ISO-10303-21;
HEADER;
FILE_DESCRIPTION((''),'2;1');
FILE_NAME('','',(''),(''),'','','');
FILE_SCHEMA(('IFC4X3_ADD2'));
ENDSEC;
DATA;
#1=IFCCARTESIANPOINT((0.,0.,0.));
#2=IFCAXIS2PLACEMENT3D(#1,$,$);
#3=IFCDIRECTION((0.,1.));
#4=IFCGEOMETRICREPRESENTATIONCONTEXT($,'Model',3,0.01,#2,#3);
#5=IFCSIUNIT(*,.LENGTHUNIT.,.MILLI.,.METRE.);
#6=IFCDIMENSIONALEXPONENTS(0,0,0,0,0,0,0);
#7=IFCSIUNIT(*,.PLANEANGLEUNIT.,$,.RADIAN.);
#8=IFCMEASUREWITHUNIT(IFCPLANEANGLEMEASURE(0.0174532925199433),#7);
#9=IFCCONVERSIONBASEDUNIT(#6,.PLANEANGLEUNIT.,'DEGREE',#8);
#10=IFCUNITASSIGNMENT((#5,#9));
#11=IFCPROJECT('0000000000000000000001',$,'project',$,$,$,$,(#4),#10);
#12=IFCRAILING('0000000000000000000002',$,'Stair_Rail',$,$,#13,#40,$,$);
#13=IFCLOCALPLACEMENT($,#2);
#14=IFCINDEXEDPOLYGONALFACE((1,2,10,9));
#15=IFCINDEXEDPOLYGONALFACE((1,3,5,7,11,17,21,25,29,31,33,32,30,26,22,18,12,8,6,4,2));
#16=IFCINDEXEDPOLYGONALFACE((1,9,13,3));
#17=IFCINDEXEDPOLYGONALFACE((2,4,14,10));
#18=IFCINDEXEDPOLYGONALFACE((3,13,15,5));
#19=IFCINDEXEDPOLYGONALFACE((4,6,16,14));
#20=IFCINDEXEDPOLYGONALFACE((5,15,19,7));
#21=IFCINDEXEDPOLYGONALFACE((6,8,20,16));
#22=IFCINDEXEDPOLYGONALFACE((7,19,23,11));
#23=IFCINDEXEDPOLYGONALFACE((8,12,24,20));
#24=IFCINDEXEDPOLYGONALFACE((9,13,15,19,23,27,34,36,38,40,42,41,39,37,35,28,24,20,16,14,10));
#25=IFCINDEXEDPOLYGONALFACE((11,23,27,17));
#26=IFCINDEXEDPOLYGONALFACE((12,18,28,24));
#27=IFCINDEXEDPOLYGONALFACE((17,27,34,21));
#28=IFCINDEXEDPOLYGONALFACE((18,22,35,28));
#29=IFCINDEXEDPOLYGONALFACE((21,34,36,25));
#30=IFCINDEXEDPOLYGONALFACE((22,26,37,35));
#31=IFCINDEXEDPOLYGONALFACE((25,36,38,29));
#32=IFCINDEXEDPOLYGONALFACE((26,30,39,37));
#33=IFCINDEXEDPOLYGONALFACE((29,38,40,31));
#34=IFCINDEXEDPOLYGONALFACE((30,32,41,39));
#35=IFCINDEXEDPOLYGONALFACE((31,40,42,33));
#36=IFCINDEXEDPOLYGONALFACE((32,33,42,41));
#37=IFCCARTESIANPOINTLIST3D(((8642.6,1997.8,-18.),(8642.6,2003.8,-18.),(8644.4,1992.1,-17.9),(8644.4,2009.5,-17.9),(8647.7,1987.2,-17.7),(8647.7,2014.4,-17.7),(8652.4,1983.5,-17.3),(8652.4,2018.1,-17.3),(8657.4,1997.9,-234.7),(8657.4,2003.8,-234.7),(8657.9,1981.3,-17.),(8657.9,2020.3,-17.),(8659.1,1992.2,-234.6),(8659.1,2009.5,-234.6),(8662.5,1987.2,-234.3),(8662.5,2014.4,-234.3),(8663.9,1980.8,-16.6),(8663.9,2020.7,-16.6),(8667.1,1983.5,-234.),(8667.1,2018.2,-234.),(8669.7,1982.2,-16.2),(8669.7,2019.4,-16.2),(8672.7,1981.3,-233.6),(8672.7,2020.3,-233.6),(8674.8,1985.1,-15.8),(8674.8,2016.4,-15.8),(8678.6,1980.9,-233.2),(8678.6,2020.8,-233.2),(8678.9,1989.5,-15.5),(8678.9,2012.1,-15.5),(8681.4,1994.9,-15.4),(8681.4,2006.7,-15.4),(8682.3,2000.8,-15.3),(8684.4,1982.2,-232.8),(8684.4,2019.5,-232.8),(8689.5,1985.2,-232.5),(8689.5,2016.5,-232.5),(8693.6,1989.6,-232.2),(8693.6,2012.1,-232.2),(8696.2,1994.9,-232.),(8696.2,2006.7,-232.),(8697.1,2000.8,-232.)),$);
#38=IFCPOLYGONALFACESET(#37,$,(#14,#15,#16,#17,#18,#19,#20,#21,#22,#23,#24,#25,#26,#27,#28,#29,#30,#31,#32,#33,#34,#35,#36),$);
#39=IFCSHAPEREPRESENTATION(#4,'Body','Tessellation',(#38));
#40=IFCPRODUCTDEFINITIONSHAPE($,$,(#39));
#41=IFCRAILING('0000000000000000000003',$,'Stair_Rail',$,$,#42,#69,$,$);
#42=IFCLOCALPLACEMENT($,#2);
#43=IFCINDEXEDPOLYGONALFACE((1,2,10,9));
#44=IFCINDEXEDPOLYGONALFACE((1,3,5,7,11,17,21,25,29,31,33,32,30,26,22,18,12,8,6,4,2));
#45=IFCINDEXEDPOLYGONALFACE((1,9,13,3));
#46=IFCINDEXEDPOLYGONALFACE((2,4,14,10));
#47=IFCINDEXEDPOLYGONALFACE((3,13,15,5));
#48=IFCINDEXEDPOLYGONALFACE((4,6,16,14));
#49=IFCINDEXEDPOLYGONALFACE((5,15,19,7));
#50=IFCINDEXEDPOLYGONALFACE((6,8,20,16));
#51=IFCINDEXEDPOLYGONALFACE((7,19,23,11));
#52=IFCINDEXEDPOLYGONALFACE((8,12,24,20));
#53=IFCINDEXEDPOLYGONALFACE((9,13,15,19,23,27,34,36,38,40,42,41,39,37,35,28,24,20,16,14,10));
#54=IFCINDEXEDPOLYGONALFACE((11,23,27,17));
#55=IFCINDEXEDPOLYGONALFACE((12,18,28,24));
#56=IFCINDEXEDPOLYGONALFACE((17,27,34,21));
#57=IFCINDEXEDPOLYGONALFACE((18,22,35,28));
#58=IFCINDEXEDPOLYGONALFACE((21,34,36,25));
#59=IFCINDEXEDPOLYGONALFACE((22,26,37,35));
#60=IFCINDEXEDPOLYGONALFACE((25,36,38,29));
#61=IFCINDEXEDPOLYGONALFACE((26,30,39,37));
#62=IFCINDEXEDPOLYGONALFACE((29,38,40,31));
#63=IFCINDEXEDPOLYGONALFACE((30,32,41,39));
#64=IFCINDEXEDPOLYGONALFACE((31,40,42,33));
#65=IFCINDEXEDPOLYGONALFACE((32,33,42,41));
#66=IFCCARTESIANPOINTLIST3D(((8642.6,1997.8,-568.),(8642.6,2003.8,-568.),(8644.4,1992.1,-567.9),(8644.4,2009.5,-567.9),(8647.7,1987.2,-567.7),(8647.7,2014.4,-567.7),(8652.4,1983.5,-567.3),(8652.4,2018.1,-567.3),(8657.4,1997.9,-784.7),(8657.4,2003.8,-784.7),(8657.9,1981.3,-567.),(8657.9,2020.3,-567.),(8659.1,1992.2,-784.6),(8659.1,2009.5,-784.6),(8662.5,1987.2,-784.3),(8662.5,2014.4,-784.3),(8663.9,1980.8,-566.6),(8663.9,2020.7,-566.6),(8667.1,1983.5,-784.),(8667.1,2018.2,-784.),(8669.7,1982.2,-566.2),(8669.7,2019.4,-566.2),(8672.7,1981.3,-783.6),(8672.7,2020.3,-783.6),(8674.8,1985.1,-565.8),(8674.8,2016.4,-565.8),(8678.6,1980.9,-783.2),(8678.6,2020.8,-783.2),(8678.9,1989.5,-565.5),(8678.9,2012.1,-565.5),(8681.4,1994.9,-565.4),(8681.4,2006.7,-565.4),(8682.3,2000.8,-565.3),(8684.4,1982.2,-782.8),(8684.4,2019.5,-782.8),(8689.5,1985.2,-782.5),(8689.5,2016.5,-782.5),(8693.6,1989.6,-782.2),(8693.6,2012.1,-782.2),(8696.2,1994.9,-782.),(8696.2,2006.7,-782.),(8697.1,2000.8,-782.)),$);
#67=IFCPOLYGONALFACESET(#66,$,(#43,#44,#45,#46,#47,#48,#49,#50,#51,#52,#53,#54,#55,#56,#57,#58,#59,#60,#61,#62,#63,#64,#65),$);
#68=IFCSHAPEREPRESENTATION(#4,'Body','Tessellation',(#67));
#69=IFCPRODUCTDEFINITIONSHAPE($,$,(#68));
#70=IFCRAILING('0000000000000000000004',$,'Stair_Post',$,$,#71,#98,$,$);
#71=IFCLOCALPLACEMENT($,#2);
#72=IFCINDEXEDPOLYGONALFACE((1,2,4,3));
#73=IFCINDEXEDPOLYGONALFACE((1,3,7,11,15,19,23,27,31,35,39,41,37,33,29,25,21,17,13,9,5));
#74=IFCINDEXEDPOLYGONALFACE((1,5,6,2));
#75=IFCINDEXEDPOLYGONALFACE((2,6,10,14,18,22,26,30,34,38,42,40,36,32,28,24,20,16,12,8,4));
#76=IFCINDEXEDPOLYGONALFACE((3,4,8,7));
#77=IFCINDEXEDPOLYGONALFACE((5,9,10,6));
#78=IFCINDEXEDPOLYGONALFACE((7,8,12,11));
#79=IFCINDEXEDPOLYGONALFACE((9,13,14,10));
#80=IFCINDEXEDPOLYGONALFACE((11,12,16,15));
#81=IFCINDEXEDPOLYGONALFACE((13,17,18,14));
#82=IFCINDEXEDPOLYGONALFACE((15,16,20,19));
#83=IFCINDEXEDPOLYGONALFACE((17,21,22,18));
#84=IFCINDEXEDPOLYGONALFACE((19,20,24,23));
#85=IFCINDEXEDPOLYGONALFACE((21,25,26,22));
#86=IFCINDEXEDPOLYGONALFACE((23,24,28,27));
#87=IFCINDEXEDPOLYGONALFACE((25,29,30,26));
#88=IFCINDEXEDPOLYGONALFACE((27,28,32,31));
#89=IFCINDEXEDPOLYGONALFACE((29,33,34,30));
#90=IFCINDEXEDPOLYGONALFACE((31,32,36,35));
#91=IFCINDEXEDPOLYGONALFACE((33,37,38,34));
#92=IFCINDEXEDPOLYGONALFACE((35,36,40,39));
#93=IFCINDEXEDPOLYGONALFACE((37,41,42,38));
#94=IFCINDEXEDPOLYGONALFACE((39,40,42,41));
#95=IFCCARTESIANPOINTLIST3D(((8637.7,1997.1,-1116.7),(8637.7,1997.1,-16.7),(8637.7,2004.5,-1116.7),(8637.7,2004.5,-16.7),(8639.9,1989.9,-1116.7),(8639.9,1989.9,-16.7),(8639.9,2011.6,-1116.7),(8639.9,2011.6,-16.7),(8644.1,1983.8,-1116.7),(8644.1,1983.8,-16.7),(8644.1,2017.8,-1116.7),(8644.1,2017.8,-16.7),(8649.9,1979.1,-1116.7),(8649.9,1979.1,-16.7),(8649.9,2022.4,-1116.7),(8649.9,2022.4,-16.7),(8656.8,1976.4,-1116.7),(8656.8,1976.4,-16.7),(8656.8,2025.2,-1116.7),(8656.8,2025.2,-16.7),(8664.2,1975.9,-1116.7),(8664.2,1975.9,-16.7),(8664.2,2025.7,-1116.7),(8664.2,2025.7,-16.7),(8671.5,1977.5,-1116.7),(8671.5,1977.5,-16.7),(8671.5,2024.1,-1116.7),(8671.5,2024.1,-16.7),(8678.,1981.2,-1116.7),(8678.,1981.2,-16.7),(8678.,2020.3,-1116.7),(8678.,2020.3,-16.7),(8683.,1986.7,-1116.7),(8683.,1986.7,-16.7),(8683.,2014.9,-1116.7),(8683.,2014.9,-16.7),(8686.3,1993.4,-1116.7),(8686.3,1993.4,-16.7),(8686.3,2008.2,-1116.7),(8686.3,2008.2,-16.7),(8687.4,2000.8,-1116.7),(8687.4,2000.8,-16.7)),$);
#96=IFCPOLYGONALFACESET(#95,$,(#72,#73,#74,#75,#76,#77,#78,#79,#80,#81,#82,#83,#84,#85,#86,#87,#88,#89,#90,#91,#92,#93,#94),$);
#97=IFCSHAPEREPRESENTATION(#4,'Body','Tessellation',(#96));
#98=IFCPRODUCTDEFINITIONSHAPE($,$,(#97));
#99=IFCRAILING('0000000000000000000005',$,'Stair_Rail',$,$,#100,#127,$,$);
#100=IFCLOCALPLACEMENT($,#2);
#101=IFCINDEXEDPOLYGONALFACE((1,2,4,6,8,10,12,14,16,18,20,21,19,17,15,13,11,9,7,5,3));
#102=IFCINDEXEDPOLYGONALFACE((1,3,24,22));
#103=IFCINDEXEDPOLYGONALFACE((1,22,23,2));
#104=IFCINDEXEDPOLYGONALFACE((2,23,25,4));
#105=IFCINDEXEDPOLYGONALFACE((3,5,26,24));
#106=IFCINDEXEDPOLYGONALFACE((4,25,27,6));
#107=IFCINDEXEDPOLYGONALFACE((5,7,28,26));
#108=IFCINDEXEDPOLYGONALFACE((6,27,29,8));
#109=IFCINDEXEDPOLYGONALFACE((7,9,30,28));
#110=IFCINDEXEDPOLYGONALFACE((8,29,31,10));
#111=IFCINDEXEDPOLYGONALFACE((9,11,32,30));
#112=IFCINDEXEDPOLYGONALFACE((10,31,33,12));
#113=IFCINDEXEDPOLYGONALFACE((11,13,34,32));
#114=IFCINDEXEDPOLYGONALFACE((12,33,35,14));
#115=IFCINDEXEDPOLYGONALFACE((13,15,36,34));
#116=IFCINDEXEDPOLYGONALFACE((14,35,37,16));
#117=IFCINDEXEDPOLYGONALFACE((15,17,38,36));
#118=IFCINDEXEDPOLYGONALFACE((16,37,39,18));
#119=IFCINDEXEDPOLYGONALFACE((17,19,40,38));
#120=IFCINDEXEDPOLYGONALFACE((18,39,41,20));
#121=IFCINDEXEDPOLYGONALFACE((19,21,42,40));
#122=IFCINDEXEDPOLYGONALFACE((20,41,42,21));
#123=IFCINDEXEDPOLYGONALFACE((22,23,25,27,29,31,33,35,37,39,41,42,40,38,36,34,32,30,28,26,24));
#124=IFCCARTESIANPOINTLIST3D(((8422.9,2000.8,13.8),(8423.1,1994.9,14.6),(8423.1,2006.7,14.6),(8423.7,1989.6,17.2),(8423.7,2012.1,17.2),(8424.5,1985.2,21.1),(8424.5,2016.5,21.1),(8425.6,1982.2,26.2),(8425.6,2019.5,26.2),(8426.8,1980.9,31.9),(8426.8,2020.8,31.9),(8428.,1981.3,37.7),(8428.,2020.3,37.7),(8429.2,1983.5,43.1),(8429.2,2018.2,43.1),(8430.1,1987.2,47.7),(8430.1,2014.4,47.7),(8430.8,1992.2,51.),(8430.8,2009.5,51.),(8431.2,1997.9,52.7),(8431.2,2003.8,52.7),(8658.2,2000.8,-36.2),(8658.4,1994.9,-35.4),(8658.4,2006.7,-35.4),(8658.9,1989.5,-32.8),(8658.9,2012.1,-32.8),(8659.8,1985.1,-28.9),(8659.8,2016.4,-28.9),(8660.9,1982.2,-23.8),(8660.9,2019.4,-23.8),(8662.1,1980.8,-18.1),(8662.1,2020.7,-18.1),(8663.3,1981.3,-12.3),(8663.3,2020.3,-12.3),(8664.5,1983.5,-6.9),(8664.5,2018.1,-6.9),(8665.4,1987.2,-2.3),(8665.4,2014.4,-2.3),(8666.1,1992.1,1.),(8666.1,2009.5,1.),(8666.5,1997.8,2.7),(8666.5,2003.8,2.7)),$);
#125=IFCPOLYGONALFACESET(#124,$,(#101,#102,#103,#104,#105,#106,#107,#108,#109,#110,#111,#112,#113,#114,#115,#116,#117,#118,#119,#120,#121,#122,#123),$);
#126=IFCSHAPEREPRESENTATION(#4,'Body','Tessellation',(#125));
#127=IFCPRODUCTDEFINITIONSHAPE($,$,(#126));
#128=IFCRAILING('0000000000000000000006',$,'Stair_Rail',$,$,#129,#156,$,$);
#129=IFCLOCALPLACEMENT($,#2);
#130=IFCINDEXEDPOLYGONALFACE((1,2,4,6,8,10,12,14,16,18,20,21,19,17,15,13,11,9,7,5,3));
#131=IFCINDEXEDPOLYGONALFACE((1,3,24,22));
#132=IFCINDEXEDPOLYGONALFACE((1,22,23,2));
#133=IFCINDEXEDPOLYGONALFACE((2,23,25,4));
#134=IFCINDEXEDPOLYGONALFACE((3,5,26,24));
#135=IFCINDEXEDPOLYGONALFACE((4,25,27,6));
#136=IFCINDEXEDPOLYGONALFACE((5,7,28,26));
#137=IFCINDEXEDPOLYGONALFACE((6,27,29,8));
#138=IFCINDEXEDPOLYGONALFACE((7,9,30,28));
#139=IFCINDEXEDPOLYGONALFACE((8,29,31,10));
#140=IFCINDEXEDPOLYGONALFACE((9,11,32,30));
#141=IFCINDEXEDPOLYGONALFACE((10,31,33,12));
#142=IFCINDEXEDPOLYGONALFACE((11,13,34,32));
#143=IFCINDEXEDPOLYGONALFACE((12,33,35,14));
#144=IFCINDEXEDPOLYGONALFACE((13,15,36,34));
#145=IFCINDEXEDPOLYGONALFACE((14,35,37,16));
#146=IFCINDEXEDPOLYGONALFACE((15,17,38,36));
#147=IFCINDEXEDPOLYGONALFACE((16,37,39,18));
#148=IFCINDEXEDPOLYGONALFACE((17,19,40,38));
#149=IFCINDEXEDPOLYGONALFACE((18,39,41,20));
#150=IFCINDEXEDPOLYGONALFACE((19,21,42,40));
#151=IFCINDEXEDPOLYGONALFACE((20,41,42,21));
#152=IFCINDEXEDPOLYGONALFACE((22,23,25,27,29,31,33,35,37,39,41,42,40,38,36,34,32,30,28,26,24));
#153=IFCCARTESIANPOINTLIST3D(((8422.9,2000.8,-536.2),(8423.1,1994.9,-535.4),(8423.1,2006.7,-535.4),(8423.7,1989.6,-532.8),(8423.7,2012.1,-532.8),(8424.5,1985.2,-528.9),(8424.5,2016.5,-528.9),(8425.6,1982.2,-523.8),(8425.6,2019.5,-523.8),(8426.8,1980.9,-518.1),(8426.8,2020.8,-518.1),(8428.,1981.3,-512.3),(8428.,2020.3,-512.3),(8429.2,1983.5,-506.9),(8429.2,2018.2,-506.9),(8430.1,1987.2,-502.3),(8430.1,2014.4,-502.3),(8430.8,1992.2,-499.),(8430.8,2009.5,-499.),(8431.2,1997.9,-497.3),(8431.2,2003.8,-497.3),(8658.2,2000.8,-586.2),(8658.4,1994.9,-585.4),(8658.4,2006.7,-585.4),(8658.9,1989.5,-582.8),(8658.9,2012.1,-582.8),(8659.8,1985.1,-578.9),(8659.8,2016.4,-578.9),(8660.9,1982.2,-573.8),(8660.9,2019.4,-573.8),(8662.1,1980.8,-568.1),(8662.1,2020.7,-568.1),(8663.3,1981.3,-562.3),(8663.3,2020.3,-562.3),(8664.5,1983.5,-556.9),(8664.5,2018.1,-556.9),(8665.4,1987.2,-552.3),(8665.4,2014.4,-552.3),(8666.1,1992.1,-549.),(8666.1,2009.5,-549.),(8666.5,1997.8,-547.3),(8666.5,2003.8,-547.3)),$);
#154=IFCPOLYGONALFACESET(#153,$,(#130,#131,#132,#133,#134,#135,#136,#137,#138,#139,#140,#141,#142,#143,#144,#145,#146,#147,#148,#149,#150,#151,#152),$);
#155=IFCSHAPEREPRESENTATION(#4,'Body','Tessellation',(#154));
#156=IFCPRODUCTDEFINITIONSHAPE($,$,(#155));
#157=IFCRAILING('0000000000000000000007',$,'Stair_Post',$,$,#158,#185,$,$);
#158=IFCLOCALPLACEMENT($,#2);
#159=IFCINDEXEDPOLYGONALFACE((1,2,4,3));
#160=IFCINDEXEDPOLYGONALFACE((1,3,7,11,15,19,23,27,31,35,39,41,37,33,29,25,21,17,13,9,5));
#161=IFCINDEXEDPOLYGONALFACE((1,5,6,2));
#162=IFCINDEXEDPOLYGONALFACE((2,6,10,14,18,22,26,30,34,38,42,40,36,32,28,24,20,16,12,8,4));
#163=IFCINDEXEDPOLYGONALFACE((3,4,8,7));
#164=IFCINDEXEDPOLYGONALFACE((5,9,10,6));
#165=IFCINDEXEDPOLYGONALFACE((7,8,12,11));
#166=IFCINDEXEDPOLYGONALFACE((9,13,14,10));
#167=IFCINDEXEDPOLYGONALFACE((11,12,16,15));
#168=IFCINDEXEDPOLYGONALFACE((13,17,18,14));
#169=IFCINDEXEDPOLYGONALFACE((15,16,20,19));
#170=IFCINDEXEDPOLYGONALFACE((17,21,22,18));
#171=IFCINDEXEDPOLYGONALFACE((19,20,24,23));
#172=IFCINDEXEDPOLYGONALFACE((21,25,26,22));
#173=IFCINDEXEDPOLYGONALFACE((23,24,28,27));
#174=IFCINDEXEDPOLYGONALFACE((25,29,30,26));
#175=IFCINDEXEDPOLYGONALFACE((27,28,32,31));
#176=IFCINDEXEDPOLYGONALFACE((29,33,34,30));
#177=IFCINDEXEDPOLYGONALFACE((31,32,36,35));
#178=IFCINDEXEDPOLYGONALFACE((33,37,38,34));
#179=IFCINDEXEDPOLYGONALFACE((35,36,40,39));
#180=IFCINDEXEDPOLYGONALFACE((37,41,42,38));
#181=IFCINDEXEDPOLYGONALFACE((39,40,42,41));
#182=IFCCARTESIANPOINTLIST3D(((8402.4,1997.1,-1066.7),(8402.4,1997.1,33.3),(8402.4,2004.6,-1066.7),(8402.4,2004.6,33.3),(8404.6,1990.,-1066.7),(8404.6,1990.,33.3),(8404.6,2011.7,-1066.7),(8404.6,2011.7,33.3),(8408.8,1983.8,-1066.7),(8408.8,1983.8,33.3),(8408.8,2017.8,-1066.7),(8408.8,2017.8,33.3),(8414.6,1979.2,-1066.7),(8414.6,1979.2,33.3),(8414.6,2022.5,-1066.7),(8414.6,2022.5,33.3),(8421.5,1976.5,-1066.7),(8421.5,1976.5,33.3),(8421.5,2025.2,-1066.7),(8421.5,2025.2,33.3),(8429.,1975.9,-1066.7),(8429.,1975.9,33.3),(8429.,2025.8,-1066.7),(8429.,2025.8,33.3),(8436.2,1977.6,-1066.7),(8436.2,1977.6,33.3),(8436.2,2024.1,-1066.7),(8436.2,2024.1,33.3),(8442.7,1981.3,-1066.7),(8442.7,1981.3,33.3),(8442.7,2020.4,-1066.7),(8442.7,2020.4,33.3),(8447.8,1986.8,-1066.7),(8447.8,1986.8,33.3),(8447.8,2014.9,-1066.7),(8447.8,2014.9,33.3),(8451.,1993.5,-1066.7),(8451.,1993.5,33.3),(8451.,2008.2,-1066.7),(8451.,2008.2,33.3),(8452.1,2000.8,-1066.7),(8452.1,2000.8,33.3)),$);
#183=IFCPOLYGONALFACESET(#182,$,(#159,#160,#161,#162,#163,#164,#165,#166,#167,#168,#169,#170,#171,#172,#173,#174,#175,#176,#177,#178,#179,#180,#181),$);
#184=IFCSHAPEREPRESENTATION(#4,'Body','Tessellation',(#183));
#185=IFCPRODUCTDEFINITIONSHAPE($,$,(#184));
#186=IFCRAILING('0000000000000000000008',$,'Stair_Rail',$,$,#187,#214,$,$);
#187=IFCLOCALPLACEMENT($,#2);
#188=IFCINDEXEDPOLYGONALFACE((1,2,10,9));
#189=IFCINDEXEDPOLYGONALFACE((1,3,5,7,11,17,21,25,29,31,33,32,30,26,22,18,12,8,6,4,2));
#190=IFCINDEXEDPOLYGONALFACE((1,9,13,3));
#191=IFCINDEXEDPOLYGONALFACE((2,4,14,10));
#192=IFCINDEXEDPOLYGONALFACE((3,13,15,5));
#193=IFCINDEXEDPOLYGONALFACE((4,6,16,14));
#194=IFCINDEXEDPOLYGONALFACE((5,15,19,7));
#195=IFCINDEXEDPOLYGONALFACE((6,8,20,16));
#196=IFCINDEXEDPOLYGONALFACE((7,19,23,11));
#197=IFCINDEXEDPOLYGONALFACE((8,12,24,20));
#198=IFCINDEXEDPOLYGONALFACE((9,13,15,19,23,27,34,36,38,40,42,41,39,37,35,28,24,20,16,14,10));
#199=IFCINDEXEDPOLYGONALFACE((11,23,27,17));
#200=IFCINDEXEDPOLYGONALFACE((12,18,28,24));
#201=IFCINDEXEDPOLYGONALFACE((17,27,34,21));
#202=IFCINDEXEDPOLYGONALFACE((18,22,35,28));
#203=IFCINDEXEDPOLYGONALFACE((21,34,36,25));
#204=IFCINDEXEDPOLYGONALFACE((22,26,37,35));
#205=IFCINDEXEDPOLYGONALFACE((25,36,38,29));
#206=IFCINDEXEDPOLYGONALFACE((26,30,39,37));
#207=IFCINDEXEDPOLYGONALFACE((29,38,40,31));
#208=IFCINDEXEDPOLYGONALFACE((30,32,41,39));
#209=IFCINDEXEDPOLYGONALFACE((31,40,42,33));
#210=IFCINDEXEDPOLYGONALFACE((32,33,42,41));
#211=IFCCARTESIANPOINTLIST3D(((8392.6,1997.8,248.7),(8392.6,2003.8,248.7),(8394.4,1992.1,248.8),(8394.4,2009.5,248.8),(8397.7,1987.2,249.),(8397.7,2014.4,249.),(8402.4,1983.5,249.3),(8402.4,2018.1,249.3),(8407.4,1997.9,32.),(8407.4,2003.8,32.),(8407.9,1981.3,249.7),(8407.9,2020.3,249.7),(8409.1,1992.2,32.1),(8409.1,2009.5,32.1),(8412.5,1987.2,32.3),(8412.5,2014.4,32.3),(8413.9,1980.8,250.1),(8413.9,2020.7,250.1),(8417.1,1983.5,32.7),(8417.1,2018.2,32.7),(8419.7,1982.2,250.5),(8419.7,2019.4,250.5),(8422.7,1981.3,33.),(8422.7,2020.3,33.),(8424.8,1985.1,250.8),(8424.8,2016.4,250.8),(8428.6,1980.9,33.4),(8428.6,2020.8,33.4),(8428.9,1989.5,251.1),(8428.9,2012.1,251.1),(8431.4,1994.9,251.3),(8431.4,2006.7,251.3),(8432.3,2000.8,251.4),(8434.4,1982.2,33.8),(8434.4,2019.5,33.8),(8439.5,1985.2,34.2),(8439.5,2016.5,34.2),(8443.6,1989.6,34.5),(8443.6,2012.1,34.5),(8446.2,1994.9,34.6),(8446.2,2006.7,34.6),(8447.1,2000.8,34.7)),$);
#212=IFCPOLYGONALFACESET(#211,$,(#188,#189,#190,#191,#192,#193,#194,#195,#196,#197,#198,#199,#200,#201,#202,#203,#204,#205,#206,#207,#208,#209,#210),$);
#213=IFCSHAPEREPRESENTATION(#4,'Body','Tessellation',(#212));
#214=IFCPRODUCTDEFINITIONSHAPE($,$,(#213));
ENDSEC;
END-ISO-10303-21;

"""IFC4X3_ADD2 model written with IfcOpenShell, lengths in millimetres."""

from ifc_helpers import new_model, entity, si_unit, converted_unit, direction, frame, origin, context, project, circle, extrude, element, save


model = new_model("IFC4X3_ADD2")

# Units and contexts
model_context = context("Model", 3, precision=0.01, world=origin(), true_north=direction((0.0, 1.0)))
ifc_project = project(units=[si_unit("LENGTHUNIT", "METRE", prefix="MILLI"), converted_unit("PLANEANGLEUNIT", "DEGREE", entity("IfcPlaneAngleMeasure", 0.0174532925199433), si_unit("PLANEANGLEUNIT", "RADIAN"), dimensions=[0, 0, 0, 0, 0, 0, 0])], contexts=[model_context])

# Railings
element("IfcRailing", 1, Name="Stair_Rail", context=model_context, shape_type="SweptSolid", body=[
    entity("IfcSweptDiskSolid", entity("IfcPolyline", [entity("IfcCartesianPoint", [8677.1, 2000.8, -233.3]), entity("IfcCartesianPoint", [8662.4, 2000.8, -16.7])]), 20.0),
])
element("IfcRailing", 2, Name="Stair_Rail", context=model_context, shape_type="SweptSolid", body=[
    entity("IfcSweptDiskSolid", entity("IfcPolyline", [entity("IfcCartesianPoint", [8677.1, 2000.8, -783.3]), entity("IfcCartesianPoint", [8662.4, 2000.8, -566.7])]), 20.0),
])
element("IfcRailing", 3, Name="Stair_Post", context=model_context, shape_type="SweptSolid", body=[
    extrude(circle(Radius=25.0), frame((8662.4, 2000.8, -1116.7)), (0.0, 0.0, 1.0), 1100.0),
])
element("IfcRailing", 4, Name="Stair_Rail", context=model_context, shape_type="SweptSolid", body=[
    entity("IfcSweptDiskSolid", entity("IfcPolyline", [entity("IfcCartesianPoint", [8662.4, 2000.8, -16.7]), entity("IfcCartesianPoint", [8427.1, 2000.8, 33.3])]), 20.0),
])
element("IfcRailing", 5, Name="Stair_Rail", context=model_context, shape_type="SweptSolid", body=[
    entity("IfcSweptDiskSolid", entity("IfcPolyline", [entity("IfcCartesianPoint", [8662.4, 2000.8, -566.7]), entity("IfcCartesianPoint", [8427.1, 2000.8, -516.7])]), 20.0),
])
element("IfcRailing", 6, Name="Stair_Post", context=model_context, shape_type="SweptSolid", body=[
    extrude(circle(Radius=25.0), frame((8427.1, 2000.8, -1066.7)), (0.0, 0.0, 1.0), 1100.0),
])
element("IfcRailing", 7, Name="Stair_Rail", context=model_context, shape_type="SweptSolid", body=[
    entity("IfcSweptDiskSolid", entity("IfcPolyline", [entity("IfcCartesianPoint", [8427.1, 2000.8, 33.3]), entity("IfcCartesianPoint", [8412.4, 2000.8, 250.0])]), 20.0),
])

save(model, "model.ifc")
